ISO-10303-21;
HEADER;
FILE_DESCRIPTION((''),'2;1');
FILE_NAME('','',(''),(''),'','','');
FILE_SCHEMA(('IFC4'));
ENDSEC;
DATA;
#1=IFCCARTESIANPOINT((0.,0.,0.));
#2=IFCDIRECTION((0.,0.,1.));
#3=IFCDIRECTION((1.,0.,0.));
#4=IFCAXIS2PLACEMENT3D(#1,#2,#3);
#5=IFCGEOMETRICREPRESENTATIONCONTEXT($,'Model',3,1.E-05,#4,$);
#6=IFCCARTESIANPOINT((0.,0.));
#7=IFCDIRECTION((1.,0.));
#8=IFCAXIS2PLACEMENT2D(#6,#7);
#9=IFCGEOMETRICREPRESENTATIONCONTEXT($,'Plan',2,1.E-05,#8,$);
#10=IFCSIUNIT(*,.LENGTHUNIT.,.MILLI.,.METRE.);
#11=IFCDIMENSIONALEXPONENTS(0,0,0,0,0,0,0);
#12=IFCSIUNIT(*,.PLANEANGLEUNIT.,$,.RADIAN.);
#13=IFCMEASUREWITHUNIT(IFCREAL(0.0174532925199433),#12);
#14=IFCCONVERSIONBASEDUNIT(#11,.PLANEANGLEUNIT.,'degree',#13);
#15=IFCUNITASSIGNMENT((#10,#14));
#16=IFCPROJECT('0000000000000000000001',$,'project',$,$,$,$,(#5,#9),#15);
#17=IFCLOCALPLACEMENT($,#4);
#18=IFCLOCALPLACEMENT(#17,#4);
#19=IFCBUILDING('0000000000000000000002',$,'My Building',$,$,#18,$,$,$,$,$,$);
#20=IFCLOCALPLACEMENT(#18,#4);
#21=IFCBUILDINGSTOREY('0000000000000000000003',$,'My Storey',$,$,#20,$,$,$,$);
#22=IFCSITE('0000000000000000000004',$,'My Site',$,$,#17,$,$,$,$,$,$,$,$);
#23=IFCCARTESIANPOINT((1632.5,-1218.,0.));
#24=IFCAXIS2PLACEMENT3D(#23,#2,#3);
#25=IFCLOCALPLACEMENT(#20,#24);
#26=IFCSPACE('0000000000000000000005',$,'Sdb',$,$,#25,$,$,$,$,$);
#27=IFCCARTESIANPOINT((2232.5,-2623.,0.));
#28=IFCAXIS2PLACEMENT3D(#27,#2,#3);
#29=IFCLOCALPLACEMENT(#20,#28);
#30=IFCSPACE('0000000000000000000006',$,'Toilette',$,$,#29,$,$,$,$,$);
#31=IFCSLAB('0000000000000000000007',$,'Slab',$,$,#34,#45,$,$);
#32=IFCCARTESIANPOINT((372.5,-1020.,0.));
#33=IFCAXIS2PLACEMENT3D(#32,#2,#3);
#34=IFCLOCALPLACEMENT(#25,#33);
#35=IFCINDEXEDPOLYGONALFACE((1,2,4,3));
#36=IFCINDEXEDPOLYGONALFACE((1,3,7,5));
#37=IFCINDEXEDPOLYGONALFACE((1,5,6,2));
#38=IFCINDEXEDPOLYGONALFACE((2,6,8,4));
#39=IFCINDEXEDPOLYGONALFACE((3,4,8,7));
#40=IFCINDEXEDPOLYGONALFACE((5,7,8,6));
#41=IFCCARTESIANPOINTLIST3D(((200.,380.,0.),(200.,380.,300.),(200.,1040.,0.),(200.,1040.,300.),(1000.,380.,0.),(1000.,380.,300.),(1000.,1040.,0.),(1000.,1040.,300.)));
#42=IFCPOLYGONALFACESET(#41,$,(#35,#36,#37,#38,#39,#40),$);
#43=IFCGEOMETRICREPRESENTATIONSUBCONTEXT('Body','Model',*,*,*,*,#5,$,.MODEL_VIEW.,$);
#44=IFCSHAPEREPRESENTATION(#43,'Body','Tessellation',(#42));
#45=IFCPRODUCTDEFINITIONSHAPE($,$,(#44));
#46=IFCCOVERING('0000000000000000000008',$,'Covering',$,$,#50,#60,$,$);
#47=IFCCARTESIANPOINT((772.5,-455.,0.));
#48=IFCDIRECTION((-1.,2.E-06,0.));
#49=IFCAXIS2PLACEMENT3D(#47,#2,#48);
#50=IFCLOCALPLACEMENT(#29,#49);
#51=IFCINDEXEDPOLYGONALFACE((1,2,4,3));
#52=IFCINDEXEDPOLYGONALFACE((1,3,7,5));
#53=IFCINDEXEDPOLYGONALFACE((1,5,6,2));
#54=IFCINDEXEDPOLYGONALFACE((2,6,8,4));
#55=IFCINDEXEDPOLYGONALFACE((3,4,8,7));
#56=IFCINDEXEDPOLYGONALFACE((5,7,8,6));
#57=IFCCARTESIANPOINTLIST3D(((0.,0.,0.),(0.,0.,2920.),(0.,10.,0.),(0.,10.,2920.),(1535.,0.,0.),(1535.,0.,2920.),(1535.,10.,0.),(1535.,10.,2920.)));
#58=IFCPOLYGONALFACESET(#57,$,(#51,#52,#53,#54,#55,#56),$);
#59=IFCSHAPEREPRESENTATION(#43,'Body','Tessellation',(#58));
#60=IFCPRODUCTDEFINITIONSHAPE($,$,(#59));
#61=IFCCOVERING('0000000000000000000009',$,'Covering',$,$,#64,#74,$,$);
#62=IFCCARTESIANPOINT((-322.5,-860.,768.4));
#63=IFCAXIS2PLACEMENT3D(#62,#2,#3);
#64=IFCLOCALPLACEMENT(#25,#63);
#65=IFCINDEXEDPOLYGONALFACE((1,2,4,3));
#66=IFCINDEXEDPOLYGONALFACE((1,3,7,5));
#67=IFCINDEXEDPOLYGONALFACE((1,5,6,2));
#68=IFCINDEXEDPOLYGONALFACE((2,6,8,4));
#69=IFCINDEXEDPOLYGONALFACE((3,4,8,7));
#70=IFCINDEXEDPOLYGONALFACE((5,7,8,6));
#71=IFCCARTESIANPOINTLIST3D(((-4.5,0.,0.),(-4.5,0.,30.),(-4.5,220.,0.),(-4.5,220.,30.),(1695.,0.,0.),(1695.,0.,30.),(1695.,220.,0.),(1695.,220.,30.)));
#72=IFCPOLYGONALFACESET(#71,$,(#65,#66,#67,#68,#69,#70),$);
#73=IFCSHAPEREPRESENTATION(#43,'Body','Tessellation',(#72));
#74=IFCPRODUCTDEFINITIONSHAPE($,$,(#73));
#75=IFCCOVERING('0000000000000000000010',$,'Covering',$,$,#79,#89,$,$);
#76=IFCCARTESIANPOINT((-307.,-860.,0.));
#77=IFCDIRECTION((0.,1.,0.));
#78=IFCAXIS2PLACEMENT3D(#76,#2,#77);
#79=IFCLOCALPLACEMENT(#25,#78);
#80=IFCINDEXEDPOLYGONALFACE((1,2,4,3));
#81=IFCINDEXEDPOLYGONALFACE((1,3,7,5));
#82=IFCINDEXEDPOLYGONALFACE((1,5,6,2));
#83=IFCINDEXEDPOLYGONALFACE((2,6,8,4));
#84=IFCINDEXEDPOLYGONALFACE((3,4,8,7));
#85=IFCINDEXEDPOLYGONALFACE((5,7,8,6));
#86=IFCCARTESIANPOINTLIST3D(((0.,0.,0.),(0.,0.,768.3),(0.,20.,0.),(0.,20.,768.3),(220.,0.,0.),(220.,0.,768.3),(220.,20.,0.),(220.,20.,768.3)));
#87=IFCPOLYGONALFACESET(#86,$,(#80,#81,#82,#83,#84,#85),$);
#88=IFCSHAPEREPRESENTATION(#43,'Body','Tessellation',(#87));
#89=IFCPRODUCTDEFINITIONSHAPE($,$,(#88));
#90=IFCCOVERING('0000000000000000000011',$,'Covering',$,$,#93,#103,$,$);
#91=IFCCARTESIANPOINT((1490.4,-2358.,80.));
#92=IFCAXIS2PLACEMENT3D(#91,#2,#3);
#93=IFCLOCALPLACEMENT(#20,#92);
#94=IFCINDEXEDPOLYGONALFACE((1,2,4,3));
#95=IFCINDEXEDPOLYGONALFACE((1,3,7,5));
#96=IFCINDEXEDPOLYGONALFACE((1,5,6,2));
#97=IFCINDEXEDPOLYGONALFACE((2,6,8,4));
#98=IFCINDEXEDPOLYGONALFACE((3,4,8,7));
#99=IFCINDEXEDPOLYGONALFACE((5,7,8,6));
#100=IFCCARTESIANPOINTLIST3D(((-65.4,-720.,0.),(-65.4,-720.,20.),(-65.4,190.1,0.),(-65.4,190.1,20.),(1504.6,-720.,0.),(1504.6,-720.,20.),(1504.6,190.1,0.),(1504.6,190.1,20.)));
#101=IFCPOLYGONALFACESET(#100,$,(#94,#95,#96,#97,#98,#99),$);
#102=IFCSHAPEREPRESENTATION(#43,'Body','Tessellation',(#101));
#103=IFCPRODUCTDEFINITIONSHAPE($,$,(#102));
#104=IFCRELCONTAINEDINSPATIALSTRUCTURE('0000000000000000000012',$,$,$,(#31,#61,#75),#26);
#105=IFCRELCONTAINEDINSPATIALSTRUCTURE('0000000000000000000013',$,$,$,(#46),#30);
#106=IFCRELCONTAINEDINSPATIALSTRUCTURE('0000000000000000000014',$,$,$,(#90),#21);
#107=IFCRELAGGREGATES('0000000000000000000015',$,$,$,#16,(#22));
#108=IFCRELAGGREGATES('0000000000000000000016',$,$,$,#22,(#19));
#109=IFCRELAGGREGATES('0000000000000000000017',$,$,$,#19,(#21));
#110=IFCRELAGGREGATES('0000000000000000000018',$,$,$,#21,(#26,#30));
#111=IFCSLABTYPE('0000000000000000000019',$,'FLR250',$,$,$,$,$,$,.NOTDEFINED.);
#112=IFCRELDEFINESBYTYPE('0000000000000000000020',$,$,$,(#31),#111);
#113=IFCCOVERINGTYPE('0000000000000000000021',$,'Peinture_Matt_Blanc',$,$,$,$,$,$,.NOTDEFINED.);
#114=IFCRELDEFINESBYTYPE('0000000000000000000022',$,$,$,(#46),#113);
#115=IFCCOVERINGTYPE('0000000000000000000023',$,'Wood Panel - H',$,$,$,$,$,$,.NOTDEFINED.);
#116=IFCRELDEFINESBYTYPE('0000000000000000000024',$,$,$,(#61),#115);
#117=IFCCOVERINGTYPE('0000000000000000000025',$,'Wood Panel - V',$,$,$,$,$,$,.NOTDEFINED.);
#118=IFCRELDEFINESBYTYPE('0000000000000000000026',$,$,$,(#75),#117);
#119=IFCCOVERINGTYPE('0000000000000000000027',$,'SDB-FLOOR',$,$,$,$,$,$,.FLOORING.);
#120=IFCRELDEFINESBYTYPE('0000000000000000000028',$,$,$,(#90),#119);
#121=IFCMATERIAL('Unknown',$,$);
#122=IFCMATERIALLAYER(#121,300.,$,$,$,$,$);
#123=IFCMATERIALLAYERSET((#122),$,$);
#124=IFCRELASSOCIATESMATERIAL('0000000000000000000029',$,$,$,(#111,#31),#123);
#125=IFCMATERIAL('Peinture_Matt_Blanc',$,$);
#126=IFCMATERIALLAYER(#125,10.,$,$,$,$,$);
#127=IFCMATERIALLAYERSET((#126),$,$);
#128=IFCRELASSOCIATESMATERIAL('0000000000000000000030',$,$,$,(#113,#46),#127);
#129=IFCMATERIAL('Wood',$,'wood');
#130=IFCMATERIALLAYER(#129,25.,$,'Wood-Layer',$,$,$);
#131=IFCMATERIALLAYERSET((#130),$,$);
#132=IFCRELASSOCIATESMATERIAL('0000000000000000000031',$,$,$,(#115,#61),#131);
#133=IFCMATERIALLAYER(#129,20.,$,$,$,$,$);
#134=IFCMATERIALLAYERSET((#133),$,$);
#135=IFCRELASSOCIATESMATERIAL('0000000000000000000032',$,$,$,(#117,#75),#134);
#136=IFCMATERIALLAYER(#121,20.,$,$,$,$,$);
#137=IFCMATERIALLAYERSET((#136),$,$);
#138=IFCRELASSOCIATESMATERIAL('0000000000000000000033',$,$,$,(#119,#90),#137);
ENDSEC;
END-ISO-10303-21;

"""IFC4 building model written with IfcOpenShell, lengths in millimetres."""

from ifc_helpers import new_model, entity, si_unit, converted_unit, frame, origin_with_axes, origin_2d_with_axis, place, context, subcontext, project, spatial, line, indexed_curve, outline, extrude, clip, halfspace, material, layer, layer_set, layer_usage, type_object, element, save


model = new_model("IFC4")

# Units and contexts
model_context = context("Model", 3, precision=1e-05, world=origin_with_axes())
plan_context = context("Plan", 2, precision=1e-05, world=origin_2d_with_axis())
body_context = subcontext(model_context, "Body", "Model", "MODEL_VIEW")
ifc_project = project(units=[si_unit("LENGTHUNIT", "METRE", prefix="MILLI"), converted_unit("PLANEANGLEUNIT", "degree", entity("IfcReal", 0.0174532925199433), si_unit("PLANEANGLEUNIT", "RADIAN"), dimensions=[0, 0, 0, 0, 0, 0, 0])], contexts=[model_context, plan_context])

# Site, building, storey, space
site_placement = place(None, origin_with_axes())
site = spatial("IfcSite", under=ifc_project, at=site_placement, Name="My Site")
building_placement = place(site_placement, origin_with_axes())
building = spatial("IfcBuilding", under=site, at=building_placement, Name="My Building")
storey_placement = place(building_placement, origin_with_axes())
storey = spatial("IfcBuildingStorey", under=building, at=storey_placement, Name="My Storey")
space_1_placement = place(storey_placement, frame((1632.5, -1218.0, 0.0), z_axis=(0.0, 0.0, 1.0), x_axis=(1.0, 0.0, 0.0)))
space_1 = spatial("IfcSpace", under=storey, at=space_1_placement, Name="Sdb")

# Slab
ifc_material_1 = material(Name="Unknown")
ifc_layer_1 = layer(ifc_material_1, 300.0)
ifc_layer_set_1 = layer_set([ifc_layer_1])
ifc_layer_usage_1 = layer_usage(ifc_layer_set_1, "AXIS3", "POSITIVE", 0.0)
slab_type = type_object("IfcSlabType", Name="FLR250", PredefinedType="NOTDEFINED", material=ifc_layer_set_1)
slab_placement = place(space_1_placement, frame((372.5, -1020.0, 0.0), z_axis=(0.0, 0.0, 1.0), x_axis=(1.0, 0.0, 0.0)))
element("IfcSlab", 1, at=slab_placement, inside=space_1, type_object=slab_type, material=ifc_layer_usage_1, Name="Slab", context=body_context, shape_type="SweptSolid", body=[
    extrude(outline(indexed_curve([(200.0, 380.0), (1000.0, 380.0), (1000.0, 1040.0), (200.0, 1040.0)], segments=[line(4, 1), line(1, 2), line(2, 3), line(3, 4)], self_intersect=False)), None, (0.0, 0.0, 1.0), 300.0),
])

# Shared definitions
space_2_placement = place(storey_placement, frame((2232.5, -2623.0, 0.0), z_axis=(0.0, 0.0, 1.0), x_axis=(1.0, 0.0, 0.0)))
space_2 = spatial("IfcSpace", under=storey, at=space_2_placement, Name="Toilette")

# Shared definitions
ifc_material_2 = material(Name="Peinture_Matt_Blanc")
ifc_layer_2 = layer(ifc_material_2, 10.0)
ifc_layer_set_2 = layer_set([ifc_layer_2])
covering_type_1 = type_object("IfcCoveringType", Name="Peinture_Matt_Blanc", PredefinedType="NOTDEFINED", material=ifc_layer_set_2)

# Coverings
ifc_layer_usage_2 = layer_usage(ifc_layer_set_2, "AXIS2", "POSITIVE", 0.0)
covering_1_placement = place(space_2_placement, frame((772.5, -455.0, 0.0), z_axis=(0.0, 0.0, 1.0), x_axis=(-1.0, 0.000002, 0.0)))
element("IfcCovering", 2, at=covering_1_placement, inside=space_2, type_object=covering_type_1, material=ifc_layer_usage_2, Name="Covering", context=body_context, shape_type="Clipping", body=[
    clip(extrude(outline(indexed_curve([(0.0, 0.0), (0.0, 10.0), (1535.0, 10.0), (1535.0, 0.0), (0.0, 0.0)], self_intersect=False)), origin_with_axes(), (0.0, 0.0, 1.0), 2920.0), halfspace(frame((0.0, 0.0, 2920.0), z_axis=(0.0, 0.0, 1.0), x_axis=(-1.0, 0.0, 0.0)), False)),
])
ifc_material_3 = material(Name="Wood", Category="wood")
ifc_layer_3 = layer(ifc_material_3, 25.0, Name="Wood-Layer")
ifc_layer_set_3 = layer_set([ifc_layer_3])
ifc_layer_usage_3 = layer_usage(ifc_layer_set_3, "AXIS3", "POSITIVE", 0.0)
covering_type_2 = type_object("IfcCoveringType", Name="Wood Panel - H", PredefinedType="NOTDEFINED", material=ifc_layer_set_3)
covering_2_placement = place(space_1_placement, frame((-322.5, -860.0, 768.4), z_axis=(0.0, 0.0, 1.0), x_axis=(1.0, 0.0, 0.0)))
element("IfcCovering", 3, at=covering_2_placement, inside=space_1, type_object=covering_type_2, material=ifc_layer_usage_3, Name="Covering", context=body_context, shape_type="SweptSolid", body=[
    extrude(outline(indexed_curve([(-4.5, 0.0), (1695.0, 0.0), (1695.0, 220.0), (-4.5, 220.0)], segments=[line(3, 2), line(2, 1), line(1, 4), line(4, 3)], self_intersect=False)), None, (0.0, 0.0, 1.0), 30.0),
])
ifc_layer_4 = layer(ifc_material_3, 20.0)
ifc_layer_set_4 = layer_set([ifc_layer_4])
ifc_layer_usage_4 = layer_usage(ifc_layer_set_4, "AXIS2", "POSITIVE", 0.0)
covering_type_3 = type_object("IfcCoveringType", Name="Wood Panel - V", PredefinedType="NOTDEFINED", material=ifc_layer_set_4)
covering_3_placement = place(space_1_placement, frame((-307.0, -860.0, 0.0), z_axis=(0.0, 0.0, 1.0), x_axis=(0.0, 1.0, 0.0)))
element("IfcCovering", 4, at=covering_3_placement, inside=space_1, type_object=covering_type_3, material=ifc_layer_usage_4, Name="Covering", context=body_context, shape_type="Clipping", body=[
    clip(extrude(outline(indexed_curve([(0.0, 0.0), (0.0, 20.0), (220.0, 20.0), (220.0, 0.0), (0.0, 0.0)], self_intersect=False)), origin_with_axes(), (0.0, 0.0, 1.0), 768.3), halfspace(frame((0.0, 0.0, 768.4), z_axis=(0.0, 0.0, 1.0), x_axis=(-1.0, 0.0, 0.0)), False)),
])
ifc_layer_5 = layer(ifc_material_1, 20.0)
ifc_layer_set_5 = layer_set([ifc_layer_5])
ifc_layer_usage_5 = layer_usage(ifc_layer_set_5, "AXIS3", "POSITIVE", 0.0)
covering_type_4 = type_object("IfcCoveringType", Name="SDB-FLOOR", PredefinedType="FLOORING", material=ifc_layer_set_5)
covering_4_placement = place(storey_placement, frame((1490.4, -2358.0, 80.0), z_axis=(0.0, 0.0, 1.0), x_axis=(1.0, 0.0, 0.0)))
element("IfcCovering", 5, at=covering_4_placement, inside=storey, type_object=covering_type_4, material=ifc_layer_usage_5, Name="Covering", context=body_context, shape_type="SweptSolid", body=[
    extrude(outline(indexed_curve([(-65.4, -720.0), (-65.4, 190.1), (1504.6, 190.1), (1504.6, -720.0)], segments=[line(3, 2), line(2, 1), line(1, 4), line(4, 3)], self_intersect=False)), None, (0.0, 0.0, 1.0), 20.0),
])

save(model, "model.ifc")
